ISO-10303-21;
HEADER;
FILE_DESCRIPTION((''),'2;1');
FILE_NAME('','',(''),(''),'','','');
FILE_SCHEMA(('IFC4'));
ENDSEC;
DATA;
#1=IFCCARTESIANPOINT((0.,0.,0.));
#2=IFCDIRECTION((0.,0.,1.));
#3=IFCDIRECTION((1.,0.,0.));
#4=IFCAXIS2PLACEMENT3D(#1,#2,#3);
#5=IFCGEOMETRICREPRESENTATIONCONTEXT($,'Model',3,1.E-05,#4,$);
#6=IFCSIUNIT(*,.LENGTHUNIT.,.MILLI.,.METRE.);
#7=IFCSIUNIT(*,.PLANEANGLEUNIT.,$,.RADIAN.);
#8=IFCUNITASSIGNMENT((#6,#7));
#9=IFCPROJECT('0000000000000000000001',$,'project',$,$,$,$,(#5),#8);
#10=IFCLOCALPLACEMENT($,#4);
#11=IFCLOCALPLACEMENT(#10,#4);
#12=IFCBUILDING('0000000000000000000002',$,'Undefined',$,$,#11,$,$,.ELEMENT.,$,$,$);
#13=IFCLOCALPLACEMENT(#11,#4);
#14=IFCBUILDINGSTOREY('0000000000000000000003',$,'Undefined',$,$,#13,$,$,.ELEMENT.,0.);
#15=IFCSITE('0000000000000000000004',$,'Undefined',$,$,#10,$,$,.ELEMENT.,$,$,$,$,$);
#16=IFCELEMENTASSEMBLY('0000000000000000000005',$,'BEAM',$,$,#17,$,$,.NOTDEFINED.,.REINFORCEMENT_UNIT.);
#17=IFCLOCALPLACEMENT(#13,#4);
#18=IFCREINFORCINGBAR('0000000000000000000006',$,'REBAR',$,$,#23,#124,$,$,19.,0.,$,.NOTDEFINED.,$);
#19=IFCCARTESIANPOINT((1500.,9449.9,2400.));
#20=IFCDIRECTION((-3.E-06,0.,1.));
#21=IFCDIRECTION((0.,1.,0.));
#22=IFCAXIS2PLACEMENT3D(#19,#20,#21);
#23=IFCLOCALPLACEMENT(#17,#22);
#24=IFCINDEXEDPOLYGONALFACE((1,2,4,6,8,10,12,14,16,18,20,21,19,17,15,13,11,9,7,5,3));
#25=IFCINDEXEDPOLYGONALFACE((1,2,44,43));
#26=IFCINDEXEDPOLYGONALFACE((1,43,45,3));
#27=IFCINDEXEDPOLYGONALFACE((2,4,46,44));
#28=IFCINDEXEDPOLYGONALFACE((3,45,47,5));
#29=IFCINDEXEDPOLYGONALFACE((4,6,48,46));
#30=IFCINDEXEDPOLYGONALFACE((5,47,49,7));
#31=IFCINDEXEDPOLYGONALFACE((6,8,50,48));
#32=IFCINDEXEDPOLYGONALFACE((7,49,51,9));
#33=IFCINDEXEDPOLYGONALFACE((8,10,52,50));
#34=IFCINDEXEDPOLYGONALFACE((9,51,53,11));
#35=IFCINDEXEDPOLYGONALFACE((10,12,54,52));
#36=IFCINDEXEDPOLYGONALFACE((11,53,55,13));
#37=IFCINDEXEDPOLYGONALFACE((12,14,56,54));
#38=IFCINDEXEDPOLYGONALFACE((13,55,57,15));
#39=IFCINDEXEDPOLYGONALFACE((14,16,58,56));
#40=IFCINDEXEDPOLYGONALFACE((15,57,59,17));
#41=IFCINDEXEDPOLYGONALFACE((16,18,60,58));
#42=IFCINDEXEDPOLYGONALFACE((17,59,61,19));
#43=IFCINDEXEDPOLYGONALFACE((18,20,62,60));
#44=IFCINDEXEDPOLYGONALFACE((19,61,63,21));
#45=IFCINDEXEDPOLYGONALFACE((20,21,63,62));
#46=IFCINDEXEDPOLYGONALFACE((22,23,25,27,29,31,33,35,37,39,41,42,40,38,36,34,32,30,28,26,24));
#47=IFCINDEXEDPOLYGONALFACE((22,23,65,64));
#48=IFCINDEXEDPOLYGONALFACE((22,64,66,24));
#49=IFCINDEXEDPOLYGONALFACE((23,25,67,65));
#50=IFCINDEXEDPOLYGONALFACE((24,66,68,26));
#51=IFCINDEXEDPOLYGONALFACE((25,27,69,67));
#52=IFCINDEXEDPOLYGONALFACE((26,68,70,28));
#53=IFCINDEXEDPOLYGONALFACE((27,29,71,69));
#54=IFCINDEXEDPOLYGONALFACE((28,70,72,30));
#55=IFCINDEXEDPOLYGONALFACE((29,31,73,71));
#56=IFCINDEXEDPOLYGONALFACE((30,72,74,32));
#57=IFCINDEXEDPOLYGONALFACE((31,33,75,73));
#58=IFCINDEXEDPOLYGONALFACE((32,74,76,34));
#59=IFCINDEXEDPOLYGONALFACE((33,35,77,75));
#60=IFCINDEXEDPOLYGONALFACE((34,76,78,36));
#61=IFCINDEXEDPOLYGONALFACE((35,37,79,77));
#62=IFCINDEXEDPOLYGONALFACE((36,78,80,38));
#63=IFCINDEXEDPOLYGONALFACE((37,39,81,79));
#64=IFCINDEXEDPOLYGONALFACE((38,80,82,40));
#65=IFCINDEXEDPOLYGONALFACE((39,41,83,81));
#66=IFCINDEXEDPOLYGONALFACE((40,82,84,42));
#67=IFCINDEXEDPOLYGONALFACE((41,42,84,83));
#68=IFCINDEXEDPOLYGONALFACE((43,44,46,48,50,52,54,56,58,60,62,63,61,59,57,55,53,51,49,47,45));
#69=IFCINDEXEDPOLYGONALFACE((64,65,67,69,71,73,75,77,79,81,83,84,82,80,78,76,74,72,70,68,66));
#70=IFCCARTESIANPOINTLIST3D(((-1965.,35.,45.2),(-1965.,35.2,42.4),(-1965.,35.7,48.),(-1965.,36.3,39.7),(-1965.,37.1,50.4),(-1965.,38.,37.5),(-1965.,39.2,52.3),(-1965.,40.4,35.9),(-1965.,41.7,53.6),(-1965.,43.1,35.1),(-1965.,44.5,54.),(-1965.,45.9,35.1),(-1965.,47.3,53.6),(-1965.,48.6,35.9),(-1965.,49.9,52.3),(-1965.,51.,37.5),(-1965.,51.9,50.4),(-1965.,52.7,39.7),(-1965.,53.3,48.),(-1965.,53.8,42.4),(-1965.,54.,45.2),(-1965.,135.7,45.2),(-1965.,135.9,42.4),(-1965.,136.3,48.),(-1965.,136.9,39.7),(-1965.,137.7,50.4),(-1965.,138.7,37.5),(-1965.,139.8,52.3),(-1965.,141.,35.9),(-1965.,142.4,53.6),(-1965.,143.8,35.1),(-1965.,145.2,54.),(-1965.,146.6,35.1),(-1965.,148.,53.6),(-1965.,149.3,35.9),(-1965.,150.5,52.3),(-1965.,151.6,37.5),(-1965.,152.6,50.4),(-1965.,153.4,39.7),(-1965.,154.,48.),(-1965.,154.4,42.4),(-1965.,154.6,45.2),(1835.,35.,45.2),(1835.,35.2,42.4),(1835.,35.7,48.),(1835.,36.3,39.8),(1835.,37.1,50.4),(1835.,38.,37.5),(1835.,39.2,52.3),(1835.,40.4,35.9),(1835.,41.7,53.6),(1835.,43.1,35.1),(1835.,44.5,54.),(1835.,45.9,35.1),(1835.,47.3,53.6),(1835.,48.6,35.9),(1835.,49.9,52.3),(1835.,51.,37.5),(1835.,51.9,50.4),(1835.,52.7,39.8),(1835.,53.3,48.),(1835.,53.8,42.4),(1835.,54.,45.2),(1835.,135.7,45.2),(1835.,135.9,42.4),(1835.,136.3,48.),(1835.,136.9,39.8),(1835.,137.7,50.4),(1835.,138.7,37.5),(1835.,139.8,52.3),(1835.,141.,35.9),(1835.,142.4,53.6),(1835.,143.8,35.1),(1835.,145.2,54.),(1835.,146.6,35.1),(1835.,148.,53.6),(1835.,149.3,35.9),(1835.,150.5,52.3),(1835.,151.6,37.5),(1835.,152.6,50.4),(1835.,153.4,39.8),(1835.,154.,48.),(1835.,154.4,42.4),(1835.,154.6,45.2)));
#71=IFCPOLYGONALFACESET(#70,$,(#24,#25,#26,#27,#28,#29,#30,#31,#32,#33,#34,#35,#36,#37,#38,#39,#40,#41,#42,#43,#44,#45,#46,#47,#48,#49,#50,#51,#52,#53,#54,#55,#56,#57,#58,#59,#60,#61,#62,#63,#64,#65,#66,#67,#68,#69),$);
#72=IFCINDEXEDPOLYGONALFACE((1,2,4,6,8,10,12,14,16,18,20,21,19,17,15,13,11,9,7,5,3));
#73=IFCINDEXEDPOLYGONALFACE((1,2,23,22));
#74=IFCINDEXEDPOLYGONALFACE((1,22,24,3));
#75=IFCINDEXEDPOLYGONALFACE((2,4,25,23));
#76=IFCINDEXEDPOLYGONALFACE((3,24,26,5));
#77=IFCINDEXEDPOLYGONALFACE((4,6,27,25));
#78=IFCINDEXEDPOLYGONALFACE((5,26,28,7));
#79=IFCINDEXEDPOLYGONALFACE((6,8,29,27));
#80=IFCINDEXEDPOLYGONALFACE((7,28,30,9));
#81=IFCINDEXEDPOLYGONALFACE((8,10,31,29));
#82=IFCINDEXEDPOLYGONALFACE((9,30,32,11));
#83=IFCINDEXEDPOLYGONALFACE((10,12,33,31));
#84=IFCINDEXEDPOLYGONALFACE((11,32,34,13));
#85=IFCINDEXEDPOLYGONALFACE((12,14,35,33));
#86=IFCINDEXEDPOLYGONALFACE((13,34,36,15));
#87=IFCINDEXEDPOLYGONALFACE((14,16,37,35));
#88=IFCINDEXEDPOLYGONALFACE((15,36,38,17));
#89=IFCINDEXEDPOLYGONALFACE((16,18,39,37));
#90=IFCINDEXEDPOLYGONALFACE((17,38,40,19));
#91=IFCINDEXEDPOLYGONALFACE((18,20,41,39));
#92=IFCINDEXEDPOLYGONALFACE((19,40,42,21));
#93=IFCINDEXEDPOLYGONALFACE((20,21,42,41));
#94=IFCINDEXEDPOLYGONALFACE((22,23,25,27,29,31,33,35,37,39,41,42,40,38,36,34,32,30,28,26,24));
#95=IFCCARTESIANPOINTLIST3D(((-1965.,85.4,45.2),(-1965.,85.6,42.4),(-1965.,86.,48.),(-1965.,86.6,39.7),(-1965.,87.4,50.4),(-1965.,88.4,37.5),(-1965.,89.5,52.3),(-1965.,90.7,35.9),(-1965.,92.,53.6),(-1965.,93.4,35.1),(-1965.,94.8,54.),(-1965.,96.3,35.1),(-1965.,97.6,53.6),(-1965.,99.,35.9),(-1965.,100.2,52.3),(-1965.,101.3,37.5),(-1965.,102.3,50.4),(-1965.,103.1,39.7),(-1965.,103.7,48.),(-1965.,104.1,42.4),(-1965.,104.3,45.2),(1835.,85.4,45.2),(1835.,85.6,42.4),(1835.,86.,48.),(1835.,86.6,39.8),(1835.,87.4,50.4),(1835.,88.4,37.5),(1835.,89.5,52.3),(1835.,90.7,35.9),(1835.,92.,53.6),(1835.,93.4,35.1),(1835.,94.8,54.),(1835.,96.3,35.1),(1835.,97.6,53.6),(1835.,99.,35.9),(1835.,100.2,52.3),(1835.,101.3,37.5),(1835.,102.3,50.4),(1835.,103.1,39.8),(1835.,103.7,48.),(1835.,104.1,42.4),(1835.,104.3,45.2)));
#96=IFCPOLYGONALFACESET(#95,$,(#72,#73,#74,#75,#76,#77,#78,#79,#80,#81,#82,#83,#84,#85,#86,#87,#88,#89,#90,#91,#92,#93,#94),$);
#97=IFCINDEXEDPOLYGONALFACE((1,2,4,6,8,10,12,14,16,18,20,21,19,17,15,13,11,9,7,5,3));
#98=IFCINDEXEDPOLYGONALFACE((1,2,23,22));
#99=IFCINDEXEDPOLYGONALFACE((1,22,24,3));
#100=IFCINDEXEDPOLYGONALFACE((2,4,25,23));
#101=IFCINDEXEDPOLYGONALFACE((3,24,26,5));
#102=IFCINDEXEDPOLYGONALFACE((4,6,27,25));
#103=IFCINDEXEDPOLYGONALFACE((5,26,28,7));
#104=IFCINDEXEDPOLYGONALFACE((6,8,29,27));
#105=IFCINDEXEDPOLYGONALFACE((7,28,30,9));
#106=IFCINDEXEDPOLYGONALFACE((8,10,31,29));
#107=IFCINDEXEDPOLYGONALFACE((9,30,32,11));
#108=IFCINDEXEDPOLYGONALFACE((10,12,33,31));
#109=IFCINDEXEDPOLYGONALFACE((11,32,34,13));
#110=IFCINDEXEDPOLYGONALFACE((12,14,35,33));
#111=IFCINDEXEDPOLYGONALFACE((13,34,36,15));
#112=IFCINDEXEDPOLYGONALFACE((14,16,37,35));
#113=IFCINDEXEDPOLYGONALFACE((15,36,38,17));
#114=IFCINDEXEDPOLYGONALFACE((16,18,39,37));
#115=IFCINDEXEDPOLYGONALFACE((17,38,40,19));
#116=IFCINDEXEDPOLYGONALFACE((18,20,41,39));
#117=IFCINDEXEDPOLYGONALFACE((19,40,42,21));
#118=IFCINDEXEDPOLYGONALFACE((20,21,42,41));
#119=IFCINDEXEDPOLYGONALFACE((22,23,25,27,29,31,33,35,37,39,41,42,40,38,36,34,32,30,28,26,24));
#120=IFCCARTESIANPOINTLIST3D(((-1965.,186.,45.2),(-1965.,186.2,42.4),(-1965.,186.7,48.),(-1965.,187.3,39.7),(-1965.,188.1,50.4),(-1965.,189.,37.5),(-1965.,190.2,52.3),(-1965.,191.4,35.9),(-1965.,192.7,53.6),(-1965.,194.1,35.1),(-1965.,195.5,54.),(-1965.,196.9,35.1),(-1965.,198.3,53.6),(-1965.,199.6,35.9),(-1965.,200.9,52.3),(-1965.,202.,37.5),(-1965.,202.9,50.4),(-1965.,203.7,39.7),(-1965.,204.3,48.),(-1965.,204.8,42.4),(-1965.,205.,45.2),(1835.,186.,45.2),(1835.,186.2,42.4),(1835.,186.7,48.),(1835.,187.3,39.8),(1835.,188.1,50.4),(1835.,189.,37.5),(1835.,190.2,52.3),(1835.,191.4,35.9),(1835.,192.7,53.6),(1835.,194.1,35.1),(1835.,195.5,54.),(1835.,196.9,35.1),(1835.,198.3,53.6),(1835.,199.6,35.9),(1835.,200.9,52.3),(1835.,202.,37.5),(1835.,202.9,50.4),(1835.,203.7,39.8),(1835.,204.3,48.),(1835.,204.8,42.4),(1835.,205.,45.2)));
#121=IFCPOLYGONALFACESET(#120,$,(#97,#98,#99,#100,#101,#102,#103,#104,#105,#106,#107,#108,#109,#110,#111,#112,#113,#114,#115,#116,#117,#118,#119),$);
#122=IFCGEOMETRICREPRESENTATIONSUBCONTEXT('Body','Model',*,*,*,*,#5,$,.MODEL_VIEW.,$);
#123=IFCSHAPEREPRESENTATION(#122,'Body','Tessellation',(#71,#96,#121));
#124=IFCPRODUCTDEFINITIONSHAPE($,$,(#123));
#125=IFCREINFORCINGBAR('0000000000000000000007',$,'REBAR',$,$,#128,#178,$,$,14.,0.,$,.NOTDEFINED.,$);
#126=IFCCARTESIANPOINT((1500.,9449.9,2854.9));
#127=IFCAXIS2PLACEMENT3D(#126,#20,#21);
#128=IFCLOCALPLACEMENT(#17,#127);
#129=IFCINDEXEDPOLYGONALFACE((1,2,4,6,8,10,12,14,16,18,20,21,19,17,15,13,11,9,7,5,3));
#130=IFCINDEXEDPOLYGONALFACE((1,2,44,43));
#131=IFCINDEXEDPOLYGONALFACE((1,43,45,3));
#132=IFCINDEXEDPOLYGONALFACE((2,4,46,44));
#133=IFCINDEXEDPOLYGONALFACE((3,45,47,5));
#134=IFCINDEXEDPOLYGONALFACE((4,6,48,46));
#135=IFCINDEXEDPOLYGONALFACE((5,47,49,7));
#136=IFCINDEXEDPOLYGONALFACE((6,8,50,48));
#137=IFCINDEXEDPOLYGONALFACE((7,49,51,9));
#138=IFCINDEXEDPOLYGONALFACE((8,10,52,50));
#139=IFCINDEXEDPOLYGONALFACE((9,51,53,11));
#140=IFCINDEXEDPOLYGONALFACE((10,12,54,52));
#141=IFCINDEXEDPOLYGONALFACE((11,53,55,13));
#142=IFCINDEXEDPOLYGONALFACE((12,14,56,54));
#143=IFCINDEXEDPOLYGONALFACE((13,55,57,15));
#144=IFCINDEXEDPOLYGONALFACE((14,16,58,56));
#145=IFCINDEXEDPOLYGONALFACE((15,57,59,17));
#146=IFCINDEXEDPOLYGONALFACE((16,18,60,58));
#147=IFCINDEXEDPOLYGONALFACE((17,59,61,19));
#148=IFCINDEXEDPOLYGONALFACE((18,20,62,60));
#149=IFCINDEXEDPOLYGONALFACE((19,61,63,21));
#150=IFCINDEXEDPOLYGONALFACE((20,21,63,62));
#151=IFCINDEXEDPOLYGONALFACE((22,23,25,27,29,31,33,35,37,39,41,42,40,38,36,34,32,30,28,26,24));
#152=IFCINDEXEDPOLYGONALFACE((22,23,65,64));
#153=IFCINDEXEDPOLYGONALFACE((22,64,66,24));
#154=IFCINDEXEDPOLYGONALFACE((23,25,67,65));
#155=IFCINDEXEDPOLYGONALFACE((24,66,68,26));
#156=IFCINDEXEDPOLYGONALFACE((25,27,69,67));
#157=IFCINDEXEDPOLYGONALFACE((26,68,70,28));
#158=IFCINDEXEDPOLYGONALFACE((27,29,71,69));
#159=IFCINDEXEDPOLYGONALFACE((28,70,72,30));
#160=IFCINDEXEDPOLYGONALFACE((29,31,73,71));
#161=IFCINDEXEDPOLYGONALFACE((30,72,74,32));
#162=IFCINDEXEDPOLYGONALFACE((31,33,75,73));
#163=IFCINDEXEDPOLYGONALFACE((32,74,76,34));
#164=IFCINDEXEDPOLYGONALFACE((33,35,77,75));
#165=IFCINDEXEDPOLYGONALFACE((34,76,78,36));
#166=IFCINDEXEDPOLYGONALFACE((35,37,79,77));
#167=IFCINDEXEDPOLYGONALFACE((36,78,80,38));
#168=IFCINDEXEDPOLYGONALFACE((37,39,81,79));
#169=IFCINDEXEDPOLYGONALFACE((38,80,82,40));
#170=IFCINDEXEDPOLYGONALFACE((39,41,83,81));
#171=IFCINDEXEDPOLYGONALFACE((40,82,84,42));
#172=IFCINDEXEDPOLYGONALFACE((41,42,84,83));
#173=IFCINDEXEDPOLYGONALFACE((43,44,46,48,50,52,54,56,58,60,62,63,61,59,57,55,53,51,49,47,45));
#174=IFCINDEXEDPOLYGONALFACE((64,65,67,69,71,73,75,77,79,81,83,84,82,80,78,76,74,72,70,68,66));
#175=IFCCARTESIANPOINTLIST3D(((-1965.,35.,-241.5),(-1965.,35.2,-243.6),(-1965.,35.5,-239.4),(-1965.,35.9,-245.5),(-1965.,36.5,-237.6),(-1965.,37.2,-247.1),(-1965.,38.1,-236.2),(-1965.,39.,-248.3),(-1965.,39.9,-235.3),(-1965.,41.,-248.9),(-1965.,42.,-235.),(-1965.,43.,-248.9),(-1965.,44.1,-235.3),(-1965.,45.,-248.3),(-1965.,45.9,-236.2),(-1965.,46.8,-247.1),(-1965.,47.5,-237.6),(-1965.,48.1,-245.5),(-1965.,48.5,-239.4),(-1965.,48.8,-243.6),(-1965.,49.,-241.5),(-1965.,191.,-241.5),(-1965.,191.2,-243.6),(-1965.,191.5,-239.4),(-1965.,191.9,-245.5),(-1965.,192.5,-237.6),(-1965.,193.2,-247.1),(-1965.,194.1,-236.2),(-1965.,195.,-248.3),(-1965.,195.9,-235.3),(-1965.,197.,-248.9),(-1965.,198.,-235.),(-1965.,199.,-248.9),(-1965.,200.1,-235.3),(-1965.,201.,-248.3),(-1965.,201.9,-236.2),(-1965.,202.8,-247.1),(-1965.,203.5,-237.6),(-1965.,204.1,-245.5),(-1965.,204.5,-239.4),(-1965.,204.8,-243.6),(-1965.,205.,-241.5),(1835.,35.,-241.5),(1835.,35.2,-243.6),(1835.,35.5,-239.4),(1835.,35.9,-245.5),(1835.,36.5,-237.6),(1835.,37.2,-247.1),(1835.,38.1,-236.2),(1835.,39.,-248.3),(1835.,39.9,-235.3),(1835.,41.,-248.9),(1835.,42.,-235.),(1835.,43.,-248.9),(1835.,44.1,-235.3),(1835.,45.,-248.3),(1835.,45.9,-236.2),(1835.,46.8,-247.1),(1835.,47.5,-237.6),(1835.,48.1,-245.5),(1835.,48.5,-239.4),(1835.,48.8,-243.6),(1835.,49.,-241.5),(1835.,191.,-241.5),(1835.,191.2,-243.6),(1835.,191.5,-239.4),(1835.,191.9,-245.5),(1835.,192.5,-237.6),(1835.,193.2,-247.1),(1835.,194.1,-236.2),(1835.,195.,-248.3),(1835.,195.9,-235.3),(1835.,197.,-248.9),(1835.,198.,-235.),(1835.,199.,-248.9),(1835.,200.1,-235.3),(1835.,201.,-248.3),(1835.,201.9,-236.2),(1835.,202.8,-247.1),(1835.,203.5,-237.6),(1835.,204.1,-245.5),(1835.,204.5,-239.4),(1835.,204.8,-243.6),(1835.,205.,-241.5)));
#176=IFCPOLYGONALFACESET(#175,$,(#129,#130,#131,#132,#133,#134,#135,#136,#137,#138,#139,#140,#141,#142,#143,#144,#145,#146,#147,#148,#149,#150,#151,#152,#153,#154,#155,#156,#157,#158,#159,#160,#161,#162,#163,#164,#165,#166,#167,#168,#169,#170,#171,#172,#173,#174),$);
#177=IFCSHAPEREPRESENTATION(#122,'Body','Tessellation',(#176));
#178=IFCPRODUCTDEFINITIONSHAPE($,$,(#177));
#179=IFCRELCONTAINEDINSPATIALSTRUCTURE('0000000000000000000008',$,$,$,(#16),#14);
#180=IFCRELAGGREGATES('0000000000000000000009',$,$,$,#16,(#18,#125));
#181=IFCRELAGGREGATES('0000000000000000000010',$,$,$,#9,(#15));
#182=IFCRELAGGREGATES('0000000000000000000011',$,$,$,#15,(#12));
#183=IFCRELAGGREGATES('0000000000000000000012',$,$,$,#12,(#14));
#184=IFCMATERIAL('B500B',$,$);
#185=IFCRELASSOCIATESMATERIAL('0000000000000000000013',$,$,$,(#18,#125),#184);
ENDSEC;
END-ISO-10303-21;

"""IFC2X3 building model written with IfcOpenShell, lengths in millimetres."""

from ifc_helpers import new_model, entity, si_unit, frame, origin_with_axes, place, context, subcontext, project, spatial, source, transform, mapped, material, element, aggregate, save


model = new_model("IFC2X3")

# Units and contexts
model_context = context("Model", 3, precision=1e-05, world=origin_with_axes())
body_context = subcontext(model_context, "Body", "Model", "MODEL_VIEW")
ifc_project = project(units=[si_unit("LENGTHUNIT", "METRE", prefix="MILLI"), si_unit("PLANEANGLEUNIT", "RADIAN")], contexts=[model_context])

# Site, building, storey
site_placement = place(None, origin_with_axes())
site = spatial("IfcSite", under=ifc_project, at=site_placement, Name="Undefined", CompositionType="ELEMENT")
building_placement = place(site_placement, origin_with_axes())
building = spatial("IfcBuilding", under=site, at=building_placement, Name="Undefined", CompositionType="ELEMENT")
storey_placement = place(building_placement, origin_with_axes())
storey = spatial("IfcBuildingStorey", under=building, at=storey_placement, Name="Undefined", CompositionType="ELEMENT", Elevation=0.0)

# Element assembly, reinforcing bars
assembly_1_placement = place(storey_placement, origin_with_axes())
assembly_1 = element("IfcElementAssembly", 1, at=assembly_1_placement, inside=storey, Name="BEAM", AssemblyPlace="NOTDEFINED", PredefinedType="REINFORCEMENT_UNIT")
ifc_material_1 = material(Name="B500B")
shared_shape_1 = source(origin_with_axes(), body_context, "Body", "AdvancedSweptSolid", [
    entity("IfcSweptDiskSolid", entity("IfcTrimmedCurve", entity("IfcLine", entity("IfcCartesianPoint", [0.0, 0.0, 0.0]), entity("IfcVector", entity("IfcDirection", [1.0, 0.0, 0.0]), 1.0)), [entity("IfcParameterValue", 0.0)], [entity("IfcParameterValue", 3799.999614)], True, "PARAMETER"), 9.5, None, 0.0, 3800.0),
])
shared_shape_2 = source(origin_with_axes(), body_context, "Body", "AdvancedSweptSolid", [
    entity("IfcSweptDiskSolid", entity("IfcTrimmedCurve", entity("IfcLine", entity("IfcCartesianPoint", [0.0, 0.0, 0.0]), entity("IfcVector", entity("IfcDirection", [1.0, 0.0, 0.0]), 1.0)), [entity("IfcParameterValue", 0.0)], [entity("IfcParameterValue", 3799.999614)], True, "PARAMETER"), 9.5, None, 0.0, 3800.0),
])
shared_shape_3 = source(origin_with_axes(), body_context, "Body", "AdvancedSweptSolid", [
    entity("IfcSweptDiskSolid", entity("IfcTrimmedCurve", entity("IfcLine", entity("IfcCartesianPoint", [0.0, 0.0, 0.0]), entity("IfcVector", entity("IfcDirection", [1.0, 0.0, 0.0]), 1.0)), [entity("IfcParameterValue", 0.0)], [entity("IfcParameterValue", 3799.999614)], True, "PARAMETER"), 9.5, None, 0.0, 3800.0),
])
shared_shape_4 = source(origin_with_axes(), body_context, "Body", "AdvancedSweptSolid", [
    entity("IfcSweptDiskSolid", entity("IfcTrimmedCurve", entity("IfcLine", entity("IfcCartesianPoint", [0.0, 0.0, 0.0]), entity("IfcVector", entity("IfcDirection", [1.0, 0.0, 0.0]), 1.0)), [entity("IfcParameterValue", 0.0)], [entity("IfcParameterValue", 3799.999614)], True, "PARAMETER"), 9.5, None, 0.0, 3800.0),
])
reinforcing_bar_1_placement = place(assembly_1_placement, frame((1500.0, 9449.9, 2400.0), z_axis=(-0.000003, 0.0, 1.0), x_axis=(0.0, 1.0, 0.0)))
reinforcing_bar_1 = element("IfcReinforcingBar", 2, at=reinforcing_bar_1_placement, material=ifc_material_1, Name="REBAR", BarRole="NOTDEFINED", CrossSectionArea=0.0, NominalDiameter=19.0, context=body_context, shape_type="MappedRepresentation", body=[
    mapped(shared_shape_1, transform((-1965.0, 44.5, 44.5))),
    mapped(shared_shape_2, transform((-1965.0, 94.8, 44.5))),
    mapped(shared_shape_3, transform((-1965.0, 145.2, 44.5))),
    mapped(shared_shape_4, transform((-1965.0, 195.5, 44.5))),
])
shared_shape_5 = source(origin_with_axes(), body_context, "Body", "AdvancedSweptSolid", [
    entity("IfcSweptDiskSolid", entity("IfcTrimmedCurve", entity("IfcLine", entity("IfcCartesianPoint", [0.0, 0.0, 0.0]), entity("IfcVector", entity("IfcDirection", [1.0, 0.0, 0.0]), 1.0)), [entity("IfcParameterValue", 0.0)], [entity("IfcParameterValue", 3799.999614)], True, "PARAMETER"), 7.0, None, 0.0, 3800.0),
])
shared_shape_6 = source(origin_with_axes(), body_context, "Body", "AdvancedSweptSolid", [
    entity("IfcSweptDiskSolid", entity("IfcTrimmedCurve", entity("IfcLine", entity("IfcCartesianPoint", [0.0, 0.0, 0.0]), entity("IfcVector", entity("IfcDirection", [1.0, 0.0, 0.0]), 1.0)), [entity("IfcParameterValue", 0.0)], [entity("IfcParameterValue", 3799.999614)], True, "PARAMETER"), 7.0, None, 0.0, 3800.0),
])
reinforcing_bar_2_placement = place(assembly_1_placement, frame((1500.0, 9449.9, 2854.9), z_axis=(-0.000003, 0.0, 1.0), x_axis=(0.0, 1.0, 0.0)))
reinforcing_bar_2 = element("IfcReinforcingBar", 3, at=reinforcing_bar_2_placement, material=ifc_material_1, Name="REBAR", BarRole="NOTDEFINED", CrossSectionArea=0.0, NominalDiameter=14.0, context=body_context, shape_type="MappedRepresentation", body=[
    mapped(shared_shape_5, transform((-1965.0, 42.0, -242.0))),
    mapped(shared_shape_6, transform((-1965.0, 198.0, -242.0))),
])
aggregate(assembly_1, [reinforcing_bar_1, reinforcing_bar_2])

save(model, "model.ifc")
